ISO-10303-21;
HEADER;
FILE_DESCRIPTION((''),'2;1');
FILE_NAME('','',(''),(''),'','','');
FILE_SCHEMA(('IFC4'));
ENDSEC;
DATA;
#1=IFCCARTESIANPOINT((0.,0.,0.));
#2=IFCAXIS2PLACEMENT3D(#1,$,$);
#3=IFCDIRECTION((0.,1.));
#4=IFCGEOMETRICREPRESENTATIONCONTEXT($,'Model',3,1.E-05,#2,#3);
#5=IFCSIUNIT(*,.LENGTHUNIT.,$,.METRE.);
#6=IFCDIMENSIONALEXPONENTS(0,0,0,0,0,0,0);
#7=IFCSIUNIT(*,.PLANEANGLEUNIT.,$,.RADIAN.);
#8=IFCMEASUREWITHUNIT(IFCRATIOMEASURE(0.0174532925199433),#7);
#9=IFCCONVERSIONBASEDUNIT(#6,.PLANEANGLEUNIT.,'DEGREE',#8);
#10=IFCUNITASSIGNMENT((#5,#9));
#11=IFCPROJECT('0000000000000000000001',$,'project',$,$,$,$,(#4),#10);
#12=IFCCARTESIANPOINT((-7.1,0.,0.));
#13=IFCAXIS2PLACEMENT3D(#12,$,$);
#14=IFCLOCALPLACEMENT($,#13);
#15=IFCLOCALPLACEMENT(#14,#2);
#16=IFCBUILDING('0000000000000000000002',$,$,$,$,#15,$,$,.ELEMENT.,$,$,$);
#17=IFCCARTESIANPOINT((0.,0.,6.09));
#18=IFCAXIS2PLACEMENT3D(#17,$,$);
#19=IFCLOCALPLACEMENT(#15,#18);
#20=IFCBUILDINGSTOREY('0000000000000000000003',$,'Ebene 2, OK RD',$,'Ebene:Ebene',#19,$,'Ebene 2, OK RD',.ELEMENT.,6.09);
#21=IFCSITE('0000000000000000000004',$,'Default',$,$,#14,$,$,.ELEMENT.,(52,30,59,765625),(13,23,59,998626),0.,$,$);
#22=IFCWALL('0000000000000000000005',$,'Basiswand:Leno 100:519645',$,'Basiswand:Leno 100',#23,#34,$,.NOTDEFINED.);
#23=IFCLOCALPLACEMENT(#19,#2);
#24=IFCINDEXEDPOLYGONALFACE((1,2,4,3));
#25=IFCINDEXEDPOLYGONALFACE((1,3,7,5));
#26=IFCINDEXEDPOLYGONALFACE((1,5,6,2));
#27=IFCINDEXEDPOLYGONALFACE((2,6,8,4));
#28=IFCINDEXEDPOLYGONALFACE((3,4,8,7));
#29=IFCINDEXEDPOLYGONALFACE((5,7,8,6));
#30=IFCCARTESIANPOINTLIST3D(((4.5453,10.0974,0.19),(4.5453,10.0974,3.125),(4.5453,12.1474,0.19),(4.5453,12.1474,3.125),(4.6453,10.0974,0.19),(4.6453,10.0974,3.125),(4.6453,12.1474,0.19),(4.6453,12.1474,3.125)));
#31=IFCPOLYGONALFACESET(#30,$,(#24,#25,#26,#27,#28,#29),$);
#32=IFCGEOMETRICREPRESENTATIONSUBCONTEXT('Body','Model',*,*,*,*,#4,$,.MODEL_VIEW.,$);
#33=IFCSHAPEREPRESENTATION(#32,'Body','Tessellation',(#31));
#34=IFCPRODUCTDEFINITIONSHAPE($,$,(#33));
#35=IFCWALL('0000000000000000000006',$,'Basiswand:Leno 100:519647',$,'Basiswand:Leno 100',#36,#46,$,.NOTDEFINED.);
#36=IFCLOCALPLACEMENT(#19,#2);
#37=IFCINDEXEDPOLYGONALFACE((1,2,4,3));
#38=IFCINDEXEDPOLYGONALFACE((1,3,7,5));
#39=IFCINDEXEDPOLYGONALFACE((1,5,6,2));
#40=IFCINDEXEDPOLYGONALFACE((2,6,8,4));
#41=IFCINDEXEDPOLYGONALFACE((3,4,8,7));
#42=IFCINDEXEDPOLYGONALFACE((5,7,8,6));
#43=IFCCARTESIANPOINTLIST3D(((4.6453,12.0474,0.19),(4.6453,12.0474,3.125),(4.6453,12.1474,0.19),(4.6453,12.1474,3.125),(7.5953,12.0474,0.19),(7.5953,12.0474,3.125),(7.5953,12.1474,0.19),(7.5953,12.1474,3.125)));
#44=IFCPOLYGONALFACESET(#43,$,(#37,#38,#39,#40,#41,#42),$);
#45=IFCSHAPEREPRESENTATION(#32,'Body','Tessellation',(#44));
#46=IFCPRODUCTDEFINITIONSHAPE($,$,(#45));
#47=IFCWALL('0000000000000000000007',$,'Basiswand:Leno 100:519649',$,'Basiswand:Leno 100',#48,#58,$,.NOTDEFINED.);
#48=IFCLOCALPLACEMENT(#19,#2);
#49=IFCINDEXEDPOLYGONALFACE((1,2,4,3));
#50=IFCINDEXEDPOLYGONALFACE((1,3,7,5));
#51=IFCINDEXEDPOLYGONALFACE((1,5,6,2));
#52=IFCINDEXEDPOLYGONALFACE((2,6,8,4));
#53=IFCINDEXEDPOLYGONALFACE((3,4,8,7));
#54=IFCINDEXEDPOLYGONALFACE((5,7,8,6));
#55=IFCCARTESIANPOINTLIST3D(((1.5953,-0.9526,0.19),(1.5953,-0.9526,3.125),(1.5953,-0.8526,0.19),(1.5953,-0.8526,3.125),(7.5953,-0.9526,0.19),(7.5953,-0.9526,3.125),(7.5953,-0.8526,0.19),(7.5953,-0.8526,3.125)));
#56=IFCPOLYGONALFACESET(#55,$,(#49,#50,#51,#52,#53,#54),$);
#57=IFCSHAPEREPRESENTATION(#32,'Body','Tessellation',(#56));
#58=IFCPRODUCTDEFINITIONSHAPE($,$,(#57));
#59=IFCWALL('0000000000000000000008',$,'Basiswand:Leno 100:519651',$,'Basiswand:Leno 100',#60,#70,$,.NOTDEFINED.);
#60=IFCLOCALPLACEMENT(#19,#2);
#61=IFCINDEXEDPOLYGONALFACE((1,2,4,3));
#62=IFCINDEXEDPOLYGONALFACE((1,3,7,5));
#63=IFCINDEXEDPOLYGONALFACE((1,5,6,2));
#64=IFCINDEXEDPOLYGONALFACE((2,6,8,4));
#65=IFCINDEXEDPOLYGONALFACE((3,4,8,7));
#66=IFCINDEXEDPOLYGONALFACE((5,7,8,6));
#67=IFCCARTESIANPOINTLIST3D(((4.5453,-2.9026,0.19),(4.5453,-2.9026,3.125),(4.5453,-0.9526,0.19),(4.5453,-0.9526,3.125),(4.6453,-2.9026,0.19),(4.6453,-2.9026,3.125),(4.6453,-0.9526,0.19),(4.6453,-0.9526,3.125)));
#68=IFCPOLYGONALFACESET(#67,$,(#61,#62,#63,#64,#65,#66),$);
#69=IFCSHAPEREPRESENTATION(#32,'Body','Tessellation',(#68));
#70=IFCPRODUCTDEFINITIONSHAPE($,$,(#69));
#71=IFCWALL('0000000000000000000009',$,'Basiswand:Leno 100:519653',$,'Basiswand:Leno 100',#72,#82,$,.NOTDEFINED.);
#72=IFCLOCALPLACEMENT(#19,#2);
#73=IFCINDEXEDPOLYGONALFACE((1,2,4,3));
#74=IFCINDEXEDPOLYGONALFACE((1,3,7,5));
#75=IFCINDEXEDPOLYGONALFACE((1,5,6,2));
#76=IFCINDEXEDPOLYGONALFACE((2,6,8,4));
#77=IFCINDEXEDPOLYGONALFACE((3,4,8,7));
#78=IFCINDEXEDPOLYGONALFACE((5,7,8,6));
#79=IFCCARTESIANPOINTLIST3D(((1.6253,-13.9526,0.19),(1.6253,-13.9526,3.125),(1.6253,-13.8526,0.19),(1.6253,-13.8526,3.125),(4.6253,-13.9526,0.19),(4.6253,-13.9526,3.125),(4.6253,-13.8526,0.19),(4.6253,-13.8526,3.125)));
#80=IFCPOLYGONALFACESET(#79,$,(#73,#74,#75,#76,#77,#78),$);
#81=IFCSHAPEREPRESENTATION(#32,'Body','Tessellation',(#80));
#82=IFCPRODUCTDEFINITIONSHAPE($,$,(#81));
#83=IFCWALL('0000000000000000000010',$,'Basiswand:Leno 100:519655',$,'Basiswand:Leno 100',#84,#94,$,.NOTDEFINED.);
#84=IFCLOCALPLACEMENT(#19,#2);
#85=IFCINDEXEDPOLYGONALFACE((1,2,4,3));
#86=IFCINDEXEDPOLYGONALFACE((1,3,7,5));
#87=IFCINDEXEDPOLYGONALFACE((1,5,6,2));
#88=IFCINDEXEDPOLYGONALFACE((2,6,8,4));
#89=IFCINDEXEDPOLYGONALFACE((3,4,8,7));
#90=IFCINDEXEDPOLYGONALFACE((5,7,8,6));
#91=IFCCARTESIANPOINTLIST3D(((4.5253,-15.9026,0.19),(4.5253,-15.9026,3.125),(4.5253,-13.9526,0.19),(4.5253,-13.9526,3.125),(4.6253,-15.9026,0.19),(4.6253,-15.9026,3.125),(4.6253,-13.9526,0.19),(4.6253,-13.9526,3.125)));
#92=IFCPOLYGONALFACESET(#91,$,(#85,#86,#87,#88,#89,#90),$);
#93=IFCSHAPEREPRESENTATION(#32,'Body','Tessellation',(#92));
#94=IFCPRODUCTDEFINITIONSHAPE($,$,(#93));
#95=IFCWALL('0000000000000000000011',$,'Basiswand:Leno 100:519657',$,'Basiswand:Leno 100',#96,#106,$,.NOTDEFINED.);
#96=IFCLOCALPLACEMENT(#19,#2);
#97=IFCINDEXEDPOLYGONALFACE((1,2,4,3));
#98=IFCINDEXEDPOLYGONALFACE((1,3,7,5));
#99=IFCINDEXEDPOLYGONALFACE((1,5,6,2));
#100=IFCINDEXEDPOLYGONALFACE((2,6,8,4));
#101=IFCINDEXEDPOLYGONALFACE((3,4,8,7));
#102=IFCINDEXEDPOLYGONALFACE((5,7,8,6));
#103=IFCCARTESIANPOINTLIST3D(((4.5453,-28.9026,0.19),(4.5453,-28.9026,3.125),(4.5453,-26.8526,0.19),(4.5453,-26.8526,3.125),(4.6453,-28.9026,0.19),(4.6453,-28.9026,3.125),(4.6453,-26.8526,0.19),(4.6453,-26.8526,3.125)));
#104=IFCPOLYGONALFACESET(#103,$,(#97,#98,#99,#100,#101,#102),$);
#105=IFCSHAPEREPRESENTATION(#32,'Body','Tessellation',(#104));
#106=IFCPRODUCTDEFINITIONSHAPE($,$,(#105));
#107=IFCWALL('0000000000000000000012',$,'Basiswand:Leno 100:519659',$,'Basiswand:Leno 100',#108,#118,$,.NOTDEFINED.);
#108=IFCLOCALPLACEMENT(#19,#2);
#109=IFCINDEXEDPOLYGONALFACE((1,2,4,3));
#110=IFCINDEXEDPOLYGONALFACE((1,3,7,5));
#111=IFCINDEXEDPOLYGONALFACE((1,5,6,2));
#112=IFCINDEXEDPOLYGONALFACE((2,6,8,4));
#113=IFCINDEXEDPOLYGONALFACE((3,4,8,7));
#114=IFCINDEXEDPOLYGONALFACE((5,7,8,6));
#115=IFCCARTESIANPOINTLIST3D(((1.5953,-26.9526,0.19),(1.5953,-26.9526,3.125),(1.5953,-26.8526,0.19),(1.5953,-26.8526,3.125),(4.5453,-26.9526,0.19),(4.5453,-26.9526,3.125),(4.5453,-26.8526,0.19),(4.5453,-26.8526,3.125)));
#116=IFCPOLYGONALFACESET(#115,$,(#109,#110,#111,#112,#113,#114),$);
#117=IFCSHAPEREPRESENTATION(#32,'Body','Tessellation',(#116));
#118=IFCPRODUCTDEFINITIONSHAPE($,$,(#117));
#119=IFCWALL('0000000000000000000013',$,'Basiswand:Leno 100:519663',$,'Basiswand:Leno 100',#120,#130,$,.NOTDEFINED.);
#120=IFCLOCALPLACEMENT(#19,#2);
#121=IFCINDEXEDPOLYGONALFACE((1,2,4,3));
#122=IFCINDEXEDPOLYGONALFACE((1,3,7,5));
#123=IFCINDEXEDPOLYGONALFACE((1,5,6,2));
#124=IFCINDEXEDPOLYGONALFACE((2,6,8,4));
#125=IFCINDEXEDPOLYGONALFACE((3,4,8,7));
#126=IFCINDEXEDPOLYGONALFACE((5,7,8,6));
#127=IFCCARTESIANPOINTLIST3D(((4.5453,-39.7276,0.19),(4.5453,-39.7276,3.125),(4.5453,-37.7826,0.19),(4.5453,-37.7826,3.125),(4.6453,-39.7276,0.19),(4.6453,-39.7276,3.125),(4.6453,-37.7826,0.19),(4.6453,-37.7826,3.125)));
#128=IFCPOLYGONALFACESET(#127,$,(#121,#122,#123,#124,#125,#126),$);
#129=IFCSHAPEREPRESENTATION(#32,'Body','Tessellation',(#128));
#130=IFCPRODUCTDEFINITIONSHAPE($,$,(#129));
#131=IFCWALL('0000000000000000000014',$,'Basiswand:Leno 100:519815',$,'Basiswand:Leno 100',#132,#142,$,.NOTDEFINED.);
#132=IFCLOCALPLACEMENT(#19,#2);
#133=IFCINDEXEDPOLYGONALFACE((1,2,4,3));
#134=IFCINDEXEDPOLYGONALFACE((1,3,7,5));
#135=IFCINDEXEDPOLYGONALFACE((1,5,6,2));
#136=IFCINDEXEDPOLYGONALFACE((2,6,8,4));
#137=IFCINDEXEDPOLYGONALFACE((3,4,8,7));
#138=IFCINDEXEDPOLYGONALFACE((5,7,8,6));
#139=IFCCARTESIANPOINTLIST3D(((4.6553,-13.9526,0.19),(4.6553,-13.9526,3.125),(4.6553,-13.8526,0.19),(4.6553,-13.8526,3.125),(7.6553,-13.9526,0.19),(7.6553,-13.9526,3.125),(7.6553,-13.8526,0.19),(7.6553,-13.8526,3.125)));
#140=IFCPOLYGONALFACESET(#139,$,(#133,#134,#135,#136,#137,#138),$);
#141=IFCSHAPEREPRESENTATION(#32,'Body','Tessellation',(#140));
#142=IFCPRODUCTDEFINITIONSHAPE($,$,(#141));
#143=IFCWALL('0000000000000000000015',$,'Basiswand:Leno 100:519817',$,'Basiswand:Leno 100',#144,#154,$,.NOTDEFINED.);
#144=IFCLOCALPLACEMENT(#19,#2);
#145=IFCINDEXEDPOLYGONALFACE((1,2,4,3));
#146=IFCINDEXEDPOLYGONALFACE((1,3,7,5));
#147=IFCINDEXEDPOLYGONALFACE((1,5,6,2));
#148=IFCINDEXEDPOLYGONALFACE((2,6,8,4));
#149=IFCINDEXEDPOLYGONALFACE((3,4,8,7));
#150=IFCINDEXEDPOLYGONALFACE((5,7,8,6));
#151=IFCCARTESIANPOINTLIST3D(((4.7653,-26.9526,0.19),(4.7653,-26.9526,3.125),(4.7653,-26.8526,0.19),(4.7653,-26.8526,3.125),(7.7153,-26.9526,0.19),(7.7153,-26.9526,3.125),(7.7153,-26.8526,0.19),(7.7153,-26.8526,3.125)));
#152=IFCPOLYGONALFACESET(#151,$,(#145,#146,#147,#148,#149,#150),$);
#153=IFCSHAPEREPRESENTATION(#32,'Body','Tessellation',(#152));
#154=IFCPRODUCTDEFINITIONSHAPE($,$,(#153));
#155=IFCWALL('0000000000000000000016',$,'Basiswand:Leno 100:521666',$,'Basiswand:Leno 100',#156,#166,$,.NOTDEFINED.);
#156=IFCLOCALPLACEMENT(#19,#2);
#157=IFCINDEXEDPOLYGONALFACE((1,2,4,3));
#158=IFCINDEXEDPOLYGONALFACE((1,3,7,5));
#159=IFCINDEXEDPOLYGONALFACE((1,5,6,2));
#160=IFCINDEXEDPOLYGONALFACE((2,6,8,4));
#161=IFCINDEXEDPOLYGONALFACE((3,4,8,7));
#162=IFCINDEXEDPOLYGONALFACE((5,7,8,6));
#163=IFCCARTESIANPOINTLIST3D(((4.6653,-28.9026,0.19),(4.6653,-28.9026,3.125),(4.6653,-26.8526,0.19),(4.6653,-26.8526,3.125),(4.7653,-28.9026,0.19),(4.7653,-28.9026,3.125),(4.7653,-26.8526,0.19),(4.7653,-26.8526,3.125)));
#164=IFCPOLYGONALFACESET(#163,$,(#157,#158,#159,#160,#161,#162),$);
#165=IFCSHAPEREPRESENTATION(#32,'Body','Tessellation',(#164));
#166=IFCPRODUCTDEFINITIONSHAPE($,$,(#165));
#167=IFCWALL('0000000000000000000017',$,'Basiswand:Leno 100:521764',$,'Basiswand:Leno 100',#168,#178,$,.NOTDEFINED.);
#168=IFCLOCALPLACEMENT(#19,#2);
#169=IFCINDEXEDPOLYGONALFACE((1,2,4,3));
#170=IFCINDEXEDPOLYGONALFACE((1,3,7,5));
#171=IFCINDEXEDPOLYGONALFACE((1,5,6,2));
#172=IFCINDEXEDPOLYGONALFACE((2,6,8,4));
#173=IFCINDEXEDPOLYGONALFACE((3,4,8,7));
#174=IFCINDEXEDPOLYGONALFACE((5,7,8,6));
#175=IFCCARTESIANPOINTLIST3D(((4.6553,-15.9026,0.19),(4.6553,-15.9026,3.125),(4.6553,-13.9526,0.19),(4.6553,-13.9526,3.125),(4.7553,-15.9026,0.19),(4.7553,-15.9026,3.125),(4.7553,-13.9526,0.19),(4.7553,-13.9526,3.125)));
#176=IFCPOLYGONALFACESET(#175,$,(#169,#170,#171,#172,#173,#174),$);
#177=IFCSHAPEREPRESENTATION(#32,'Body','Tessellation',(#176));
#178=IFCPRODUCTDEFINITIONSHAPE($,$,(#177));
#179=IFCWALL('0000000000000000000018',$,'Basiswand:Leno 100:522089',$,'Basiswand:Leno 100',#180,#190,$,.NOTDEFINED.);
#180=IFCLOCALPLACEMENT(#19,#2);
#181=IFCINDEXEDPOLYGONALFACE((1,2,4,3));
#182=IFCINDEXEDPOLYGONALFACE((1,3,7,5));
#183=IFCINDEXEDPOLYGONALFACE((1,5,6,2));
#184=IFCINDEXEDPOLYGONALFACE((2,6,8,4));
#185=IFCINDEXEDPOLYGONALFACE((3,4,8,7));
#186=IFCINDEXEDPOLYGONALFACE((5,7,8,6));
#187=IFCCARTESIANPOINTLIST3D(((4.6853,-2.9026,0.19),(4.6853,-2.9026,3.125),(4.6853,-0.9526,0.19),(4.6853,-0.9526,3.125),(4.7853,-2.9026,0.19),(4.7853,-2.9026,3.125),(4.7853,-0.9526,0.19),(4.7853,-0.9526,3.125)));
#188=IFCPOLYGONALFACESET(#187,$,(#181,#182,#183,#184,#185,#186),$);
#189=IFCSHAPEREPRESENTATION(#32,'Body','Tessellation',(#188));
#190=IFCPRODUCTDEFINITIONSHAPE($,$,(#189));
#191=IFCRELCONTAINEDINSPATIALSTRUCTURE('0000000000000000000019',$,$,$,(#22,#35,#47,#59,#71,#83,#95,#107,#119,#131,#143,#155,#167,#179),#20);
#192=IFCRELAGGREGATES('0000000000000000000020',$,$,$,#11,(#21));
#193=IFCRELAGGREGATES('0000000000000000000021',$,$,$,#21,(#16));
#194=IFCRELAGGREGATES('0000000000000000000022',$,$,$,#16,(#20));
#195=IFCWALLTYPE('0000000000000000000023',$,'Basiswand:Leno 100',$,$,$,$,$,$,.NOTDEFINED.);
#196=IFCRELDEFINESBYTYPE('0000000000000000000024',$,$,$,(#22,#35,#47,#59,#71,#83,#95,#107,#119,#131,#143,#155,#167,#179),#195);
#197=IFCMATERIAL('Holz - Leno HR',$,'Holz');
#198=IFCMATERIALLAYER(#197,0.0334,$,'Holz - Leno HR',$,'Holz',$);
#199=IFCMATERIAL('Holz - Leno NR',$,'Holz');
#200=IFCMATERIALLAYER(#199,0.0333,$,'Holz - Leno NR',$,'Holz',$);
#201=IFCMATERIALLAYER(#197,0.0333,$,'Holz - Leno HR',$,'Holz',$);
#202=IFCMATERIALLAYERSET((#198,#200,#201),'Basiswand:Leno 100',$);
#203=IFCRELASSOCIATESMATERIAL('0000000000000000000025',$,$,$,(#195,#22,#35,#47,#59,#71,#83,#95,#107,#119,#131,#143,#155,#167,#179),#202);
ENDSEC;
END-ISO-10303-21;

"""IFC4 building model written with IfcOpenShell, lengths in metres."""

from ifc_helpers import new_model, entity, si_unit, converted_unit, direction, frame, origin, place, context, subcontext, project, spatial, indexed_curve, outline, extrude, material, layer, layer_set, type_object, element, save


model = new_model("IFC4")

# Units and contexts
model_context = context("Model", 3, precision=1e-05, world=origin(), true_north=direction((0.0, 1.0)))
body_context = subcontext(model_context, "Body", "Model", "MODEL_VIEW")
ifc_project = project(units=[si_unit("LENGTHUNIT", "METRE"), converted_unit("PLANEANGLEUNIT", "DEGREE", entity("IfcRatioMeasure", 0.0174532925199433), si_unit("PLANEANGLEUNIT", "RADIAN"), dimensions=[0, 0, 0, 0, 0, 0, 0])], contexts=[model_context])

# Site, building, storey
site_placement = place(None, frame((-7.1, 0.0, 0.0)))
site = spatial("IfcSite", under=ifc_project, at=site_placement, Name="Default", CompositionType="ELEMENT", RefLatitude=(52, 30, 59, 765625), RefLongitude=(13, 23, 59, 998626), RefElevation=0.0)
building_placement = place(site_placement, origin())
building = spatial("IfcBuilding", under=site, at=building_placement, CompositionType="ELEMENT")
storey_placement = place(building_placement, frame((0.0, 0.0, 6.09)))
storey = spatial("IfcBuildingStorey", under=building, at=storey_placement, Name="Ebene 2, OK RD", ObjectType="Ebene:Ebene", LongName="Ebene 2, OK RD", CompositionType="ELEMENT", Elevation=6.09)

# Shared definitions
ifc_material_1 = material(Name="Holz - Leno HR", Category="Holz")
ifc_material_2 = material(Name="Holz - Leno NR", Category="Holz")

# Walls
ifc_layer_1 = layer(ifc_material_1, 0.0334, Name="Holz - Leno HR", Category="Holz")
ifc_layer_2 = layer(ifc_material_2, 0.0333, Name="Holz - Leno NR", Category="Holz")
ifc_layer_3 = layer(ifc_material_1, 0.0333, Name="Holz - Leno HR", Category="Holz")
ifc_layer_set_1 = layer_set([ifc_layer_1, ifc_layer_2, ifc_layer_3], Name="Basiswand:Leno 100")
wall_type = type_object("IfcWallType", Name="Basiswand:Leno 100", PredefinedType="NOTDEFINED", material=ifc_layer_set_1)
wall_1_placement = place(storey_placement, frame((4.5953, 10.0974, 0.19), z_axis=(0.0, 0.0, 1.0), x_axis=(0.0, 1.0, 0.0)))
element("IfcWall", 1, at=wall_1_placement, inside=storey, type_object=wall_type, material=ifc_layer_set_1, Name="Basiswand:Leno 100:519645", ObjectType="Basiswand:Leno 100", PredefinedType="NOTDEFINED", context=body_context, shape_type="SweptSolid", body=[
    extrude(outline(indexed_curve([(2.05, 0.05), (0.0, 0.05), (0.0, -0.05), (2.05, -0.05), (2.05, 0.05)], self_intersect=False)), origin(), (0.0, 0.0, 1.0), 2.935),
])
wall_2_placement = place(storey_placement, frame((7.5953, 12.0974, 0.19), z_axis=(0.0, 0.0, 1.0), x_axis=(-1.0, 0.0, 0.0)))
element("IfcWall", 2, at=wall_2_placement, inside=storey, type_object=wall_type, material=ifc_layer_set_1, Name="Basiswand:Leno 100:519647", ObjectType="Basiswand:Leno 100", PredefinedType="NOTDEFINED", context=body_context, shape_type="SweptSolid", body=[
    extrude(outline(indexed_curve([(2.95, 0.05), (0.0, 0.05), (0.0, -0.05), (2.95, -0.05), (2.95, 0.05)], self_intersect=False)), origin(), (0.0, 0.0, 1.0), 2.935),
])
wall_3_placement = place(storey_placement, frame((7.5953, -0.9026, 0.19), z_axis=(0.0, 0.0, 1.0), x_axis=(-1.0, 0.0, 0.0)))
element("IfcWall", 3, at=wall_3_placement, inside=storey, type_object=wall_type, material=ifc_layer_set_1, Name="Basiswand:Leno 100:519649", ObjectType="Basiswand:Leno 100", PredefinedType="NOTDEFINED", context=body_context, shape_type="SweptSolid", body=[
    extrude(outline(indexed_curve([(6.0, 0.05), (0.0, 0.05), (0.0, -0.05), (6.0, -0.05), (6.0, 0.05)], self_intersect=False)), origin(), (0.0, 0.0, 1.0), 2.935),
])
wall_4_placement = place(storey_placement, frame((4.5953, -2.9026, 0.19), z_axis=(0.0, 0.0, 1.0), x_axis=(0.0, 1.0, 0.0)))
element("IfcWall", 4, at=wall_4_placement, inside=storey, type_object=wall_type, material=ifc_layer_set_1, Name="Basiswand:Leno 100:519651", ObjectType="Basiswand:Leno 100", PredefinedType="NOTDEFINED", context=body_context, shape_type="SweptSolid", body=[
    extrude(outline(indexed_curve([(1.95, 0.05), (0.0, 0.05), (0.0, -0.05), (1.95, -0.05), (1.95, 0.05)], self_intersect=False)), origin(), (0.0, 0.0, 1.0), 2.935),
])
wall_5_placement = place(storey_placement, frame((1.6253, -13.9026, 0.19)))
element("IfcWall", 5, at=wall_5_placement, inside=storey, type_object=wall_type, material=ifc_layer_set_1, Name="Basiswand:Leno 100:519653", ObjectType="Basiswand:Leno 100", PredefinedType="NOTDEFINED", context=body_context, shape_type="SweptSolid", body=[
    extrude(outline(indexed_curve([(3.0, 0.05), (0.0, 0.05), (0.0, -0.05), (3.0, -0.05), (3.0, 0.05)], self_intersect=False)), origin(), (0.0, 0.0, 1.0), 2.935),
])
wall_6_placement = place(storey_placement, frame((4.5753, -15.9026, 0.19), z_axis=(0.0, 0.0, 1.0), x_axis=(0.0, 1.0, 0.0)))
element("IfcWall", 6, at=wall_6_placement, inside=storey, type_object=wall_type, material=ifc_layer_set_1, Name="Basiswand:Leno 100:519655", ObjectType="Basiswand:Leno 100", PredefinedType="NOTDEFINED", context=body_context, shape_type="SweptSolid", body=[
    extrude(outline(indexed_curve([(1.95, 0.05), (0.0, 0.05), (0.0, -0.05), (1.95, -0.05), (1.95, 0.05)], self_intersect=False)), origin(), (0.0, 0.0, 1.0), 2.935),
])
wall_7_placement = place(storey_placement, frame((4.5953, -28.9026, 0.19), z_axis=(0.0, 0.0, 1.0), x_axis=(0.0, 1.0, 0.0)))
element("IfcWall", 7, at=wall_7_placement, inside=storey, type_object=wall_type, material=ifc_layer_set_1, Name="Basiswand:Leno 100:519657", ObjectType="Basiswand:Leno 100", PredefinedType="NOTDEFINED", context=body_context, shape_type="SweptSolid", body=[
    extrude(outline(indexed_curve([(2.05, 0.05), (0.0, 0.05), (0.0, -0.05), (2.05, -0.05), (2.05, 0.05)], self_intersect=False)), origin(), (0.0, 0.0, 1.0), 2.935),
])
wall_8_placement = place(storey_placement, frame((1.5953, -26.9026, 0.19)))
element("IfcWall", 8, at=wall_8_placement, inside=storey, type_object=wall_type, material=ifc_layer_set_1, Name="Basiswand:Leno 100:519659", ObjectType="Basiswand:Leno 100", PredefinedType="NOTDEFINED", context=body_context, shape_type="SweptSolid", body=[
    extrude(outline(indexed_curve([(2.95, 0.05), (0.0, 0.05), (0.0, -0.05), (2.95, -0.05), (2.95, 0.05)], self_intersect=False)), origin(), (0.0, 0.0, 1.0), 2.935),
])
wall_9_placement = place(storey_placement, frame((4.5953, -37.7826, 0.19), z_axis=(0.0, 0.0, 1.0), x_axis=(0.0, -1.0, 0.0)))
element("IfcWall", 9, at=wall_9_placement, inside=storey, type_object=wall_type, material=ifc_layer_set_1, Name="Basiswand:Leno 100:519663", ObjectType="Basiswand:Leno 100", PredefinedType="NOTDEFINED", context=body_context, shape_type="SweptSolid", body=[
    extrude(outline(indexed_curve([(1.945, 0.05), (0.0, 0.05), (0.0, -0.05), (1.945, -0.05), (1.945, 0.05)], self_intersect=False)), origin(), (0.0, 0.0, 1.0), 2.935),
])
wall_10_placement = place(storey_placement, frame((4.6553, -13.9026, 0.19)))
element("IfcWall", 10, at=wall_10_placement, inside=storey, type_object=wall_type, material=ifc_layer_set_1, Name="Basiswand:Leno 100:519815", ObjectType="Basiswand:Leno 100", PredefinedType="NOTDEFINED", context=body_context, shape_type="SweptSolid", body=[
    extrude(outline(indexed_curve([(3.0, 0.05), (0.0, 0.05), (0.0, -0.05), (3.0, -0.05), (3.0, 0.05)], self_intersect=False)), origin(), (0.0, 0.0, 1.0), 2.935),
])
wall_11_placement = place(storey_placement, frame((7.7153, -26.9026, 0.19), z_axis=(0.0, 0.0, 1.0), x_axis=(-1.0, 0.0, 0.0)))
element("IfcWall", 11, at=wall_11_placement, inside=storey, type_object=wall_type, material=ifc_layer_set_1, Name="Basiswand:Leno 100:519817", ObjectType="Basiswand:Leno 100", PredefinedType="NOTDEFINED", context=body_context, shape_type="SweptSolid", body=[
    extrude(outline(indexed_curve([(2.95, 0.05), (0.0, 0.05), (0.0, -0.05), (2.95, -0.05), (2.95, 0.05)], self_intersect=False)), origin(), (0.0, 0.0, 1.0), 2.935),
])
wall_12_placement = place(storey_placement, frame((4.7153, -28.9026, 0.19), z_axis=(0.0, 0.0, 1.0), x_axis=(0.0, 1.0, 0.0)))
element("IfcWall", 12, at=wall_12_placement, inside=storey, type_object=wall_type, material=ifc_layer_set_1, Name="Basiswand:Leno 100:521666", ObjectType="Basiswand:Leno 100", PredefinedType="NOTDEFINED", context=body_context, shape_type="SweptSolid", body=[
    extrude(outline(indexed_curve([(2.05, 0.05), (0.0, 0.05), (0.0, -0.05), (2.05, -0.05), (2.05, 0.05)], self_intersect=False)), origin(), (0.0, 0.0, 1.0), 2.935),
])
wall_13_placement = place(storey_placement, frame((4.7053, -15.9026, 0.19), z_axis=(0.0, 0.0, 1.0), x_axis=(0.0, 1.0, 0.0)))
element("IfcWall", 13, at=wall_13_placement, inside=storey, type_object=wall_type, material=ifc_layer_set_1, Name="Basiswand:Leno 100:521764", ObjectType="Basiswand:Leno 100", PredefinedType="NOTDEFINED", context=body_context, shape_type="SweptSolid", body=[
    extrude(outline(indexed_curve([(1.95, 0.05), (0.0, 0.05), (0.0, -0.05), (1.95, -0.05), (1.95, 0.05)], self_intersect=False)), origin(), (0.0, 0.0, 1.0), 2.935),
])
wall_14_placement = place(storey_placement, frame((4.7353, -2.9026, 0.19), z_axis=(0.0, 0.0, 1.0), x_axis=(0.0, 1.0, 0.0)))
element("IfcWall", 14, at=wall_14_placement, inside=storey, type_object=wall_type, material=ifc_layer_set_1, Name="Basiswand:Leno 100:522089", ObjectType="Basiswand:Leno 100", PredefinedType="NOTDEFINED", context=body_context, shape_type="SweptSolid", body=[
    extrude(outline(indexed_curve([(1.95, 0.05), (0.0, 0.05), (0.0, -0.05), (1.95, -0.05), (1.95, 0.05)], self_intersect=False)), origin(), (0.0, 0.0, 1.0), 2.935),
])

save(model, "model.ifc")
